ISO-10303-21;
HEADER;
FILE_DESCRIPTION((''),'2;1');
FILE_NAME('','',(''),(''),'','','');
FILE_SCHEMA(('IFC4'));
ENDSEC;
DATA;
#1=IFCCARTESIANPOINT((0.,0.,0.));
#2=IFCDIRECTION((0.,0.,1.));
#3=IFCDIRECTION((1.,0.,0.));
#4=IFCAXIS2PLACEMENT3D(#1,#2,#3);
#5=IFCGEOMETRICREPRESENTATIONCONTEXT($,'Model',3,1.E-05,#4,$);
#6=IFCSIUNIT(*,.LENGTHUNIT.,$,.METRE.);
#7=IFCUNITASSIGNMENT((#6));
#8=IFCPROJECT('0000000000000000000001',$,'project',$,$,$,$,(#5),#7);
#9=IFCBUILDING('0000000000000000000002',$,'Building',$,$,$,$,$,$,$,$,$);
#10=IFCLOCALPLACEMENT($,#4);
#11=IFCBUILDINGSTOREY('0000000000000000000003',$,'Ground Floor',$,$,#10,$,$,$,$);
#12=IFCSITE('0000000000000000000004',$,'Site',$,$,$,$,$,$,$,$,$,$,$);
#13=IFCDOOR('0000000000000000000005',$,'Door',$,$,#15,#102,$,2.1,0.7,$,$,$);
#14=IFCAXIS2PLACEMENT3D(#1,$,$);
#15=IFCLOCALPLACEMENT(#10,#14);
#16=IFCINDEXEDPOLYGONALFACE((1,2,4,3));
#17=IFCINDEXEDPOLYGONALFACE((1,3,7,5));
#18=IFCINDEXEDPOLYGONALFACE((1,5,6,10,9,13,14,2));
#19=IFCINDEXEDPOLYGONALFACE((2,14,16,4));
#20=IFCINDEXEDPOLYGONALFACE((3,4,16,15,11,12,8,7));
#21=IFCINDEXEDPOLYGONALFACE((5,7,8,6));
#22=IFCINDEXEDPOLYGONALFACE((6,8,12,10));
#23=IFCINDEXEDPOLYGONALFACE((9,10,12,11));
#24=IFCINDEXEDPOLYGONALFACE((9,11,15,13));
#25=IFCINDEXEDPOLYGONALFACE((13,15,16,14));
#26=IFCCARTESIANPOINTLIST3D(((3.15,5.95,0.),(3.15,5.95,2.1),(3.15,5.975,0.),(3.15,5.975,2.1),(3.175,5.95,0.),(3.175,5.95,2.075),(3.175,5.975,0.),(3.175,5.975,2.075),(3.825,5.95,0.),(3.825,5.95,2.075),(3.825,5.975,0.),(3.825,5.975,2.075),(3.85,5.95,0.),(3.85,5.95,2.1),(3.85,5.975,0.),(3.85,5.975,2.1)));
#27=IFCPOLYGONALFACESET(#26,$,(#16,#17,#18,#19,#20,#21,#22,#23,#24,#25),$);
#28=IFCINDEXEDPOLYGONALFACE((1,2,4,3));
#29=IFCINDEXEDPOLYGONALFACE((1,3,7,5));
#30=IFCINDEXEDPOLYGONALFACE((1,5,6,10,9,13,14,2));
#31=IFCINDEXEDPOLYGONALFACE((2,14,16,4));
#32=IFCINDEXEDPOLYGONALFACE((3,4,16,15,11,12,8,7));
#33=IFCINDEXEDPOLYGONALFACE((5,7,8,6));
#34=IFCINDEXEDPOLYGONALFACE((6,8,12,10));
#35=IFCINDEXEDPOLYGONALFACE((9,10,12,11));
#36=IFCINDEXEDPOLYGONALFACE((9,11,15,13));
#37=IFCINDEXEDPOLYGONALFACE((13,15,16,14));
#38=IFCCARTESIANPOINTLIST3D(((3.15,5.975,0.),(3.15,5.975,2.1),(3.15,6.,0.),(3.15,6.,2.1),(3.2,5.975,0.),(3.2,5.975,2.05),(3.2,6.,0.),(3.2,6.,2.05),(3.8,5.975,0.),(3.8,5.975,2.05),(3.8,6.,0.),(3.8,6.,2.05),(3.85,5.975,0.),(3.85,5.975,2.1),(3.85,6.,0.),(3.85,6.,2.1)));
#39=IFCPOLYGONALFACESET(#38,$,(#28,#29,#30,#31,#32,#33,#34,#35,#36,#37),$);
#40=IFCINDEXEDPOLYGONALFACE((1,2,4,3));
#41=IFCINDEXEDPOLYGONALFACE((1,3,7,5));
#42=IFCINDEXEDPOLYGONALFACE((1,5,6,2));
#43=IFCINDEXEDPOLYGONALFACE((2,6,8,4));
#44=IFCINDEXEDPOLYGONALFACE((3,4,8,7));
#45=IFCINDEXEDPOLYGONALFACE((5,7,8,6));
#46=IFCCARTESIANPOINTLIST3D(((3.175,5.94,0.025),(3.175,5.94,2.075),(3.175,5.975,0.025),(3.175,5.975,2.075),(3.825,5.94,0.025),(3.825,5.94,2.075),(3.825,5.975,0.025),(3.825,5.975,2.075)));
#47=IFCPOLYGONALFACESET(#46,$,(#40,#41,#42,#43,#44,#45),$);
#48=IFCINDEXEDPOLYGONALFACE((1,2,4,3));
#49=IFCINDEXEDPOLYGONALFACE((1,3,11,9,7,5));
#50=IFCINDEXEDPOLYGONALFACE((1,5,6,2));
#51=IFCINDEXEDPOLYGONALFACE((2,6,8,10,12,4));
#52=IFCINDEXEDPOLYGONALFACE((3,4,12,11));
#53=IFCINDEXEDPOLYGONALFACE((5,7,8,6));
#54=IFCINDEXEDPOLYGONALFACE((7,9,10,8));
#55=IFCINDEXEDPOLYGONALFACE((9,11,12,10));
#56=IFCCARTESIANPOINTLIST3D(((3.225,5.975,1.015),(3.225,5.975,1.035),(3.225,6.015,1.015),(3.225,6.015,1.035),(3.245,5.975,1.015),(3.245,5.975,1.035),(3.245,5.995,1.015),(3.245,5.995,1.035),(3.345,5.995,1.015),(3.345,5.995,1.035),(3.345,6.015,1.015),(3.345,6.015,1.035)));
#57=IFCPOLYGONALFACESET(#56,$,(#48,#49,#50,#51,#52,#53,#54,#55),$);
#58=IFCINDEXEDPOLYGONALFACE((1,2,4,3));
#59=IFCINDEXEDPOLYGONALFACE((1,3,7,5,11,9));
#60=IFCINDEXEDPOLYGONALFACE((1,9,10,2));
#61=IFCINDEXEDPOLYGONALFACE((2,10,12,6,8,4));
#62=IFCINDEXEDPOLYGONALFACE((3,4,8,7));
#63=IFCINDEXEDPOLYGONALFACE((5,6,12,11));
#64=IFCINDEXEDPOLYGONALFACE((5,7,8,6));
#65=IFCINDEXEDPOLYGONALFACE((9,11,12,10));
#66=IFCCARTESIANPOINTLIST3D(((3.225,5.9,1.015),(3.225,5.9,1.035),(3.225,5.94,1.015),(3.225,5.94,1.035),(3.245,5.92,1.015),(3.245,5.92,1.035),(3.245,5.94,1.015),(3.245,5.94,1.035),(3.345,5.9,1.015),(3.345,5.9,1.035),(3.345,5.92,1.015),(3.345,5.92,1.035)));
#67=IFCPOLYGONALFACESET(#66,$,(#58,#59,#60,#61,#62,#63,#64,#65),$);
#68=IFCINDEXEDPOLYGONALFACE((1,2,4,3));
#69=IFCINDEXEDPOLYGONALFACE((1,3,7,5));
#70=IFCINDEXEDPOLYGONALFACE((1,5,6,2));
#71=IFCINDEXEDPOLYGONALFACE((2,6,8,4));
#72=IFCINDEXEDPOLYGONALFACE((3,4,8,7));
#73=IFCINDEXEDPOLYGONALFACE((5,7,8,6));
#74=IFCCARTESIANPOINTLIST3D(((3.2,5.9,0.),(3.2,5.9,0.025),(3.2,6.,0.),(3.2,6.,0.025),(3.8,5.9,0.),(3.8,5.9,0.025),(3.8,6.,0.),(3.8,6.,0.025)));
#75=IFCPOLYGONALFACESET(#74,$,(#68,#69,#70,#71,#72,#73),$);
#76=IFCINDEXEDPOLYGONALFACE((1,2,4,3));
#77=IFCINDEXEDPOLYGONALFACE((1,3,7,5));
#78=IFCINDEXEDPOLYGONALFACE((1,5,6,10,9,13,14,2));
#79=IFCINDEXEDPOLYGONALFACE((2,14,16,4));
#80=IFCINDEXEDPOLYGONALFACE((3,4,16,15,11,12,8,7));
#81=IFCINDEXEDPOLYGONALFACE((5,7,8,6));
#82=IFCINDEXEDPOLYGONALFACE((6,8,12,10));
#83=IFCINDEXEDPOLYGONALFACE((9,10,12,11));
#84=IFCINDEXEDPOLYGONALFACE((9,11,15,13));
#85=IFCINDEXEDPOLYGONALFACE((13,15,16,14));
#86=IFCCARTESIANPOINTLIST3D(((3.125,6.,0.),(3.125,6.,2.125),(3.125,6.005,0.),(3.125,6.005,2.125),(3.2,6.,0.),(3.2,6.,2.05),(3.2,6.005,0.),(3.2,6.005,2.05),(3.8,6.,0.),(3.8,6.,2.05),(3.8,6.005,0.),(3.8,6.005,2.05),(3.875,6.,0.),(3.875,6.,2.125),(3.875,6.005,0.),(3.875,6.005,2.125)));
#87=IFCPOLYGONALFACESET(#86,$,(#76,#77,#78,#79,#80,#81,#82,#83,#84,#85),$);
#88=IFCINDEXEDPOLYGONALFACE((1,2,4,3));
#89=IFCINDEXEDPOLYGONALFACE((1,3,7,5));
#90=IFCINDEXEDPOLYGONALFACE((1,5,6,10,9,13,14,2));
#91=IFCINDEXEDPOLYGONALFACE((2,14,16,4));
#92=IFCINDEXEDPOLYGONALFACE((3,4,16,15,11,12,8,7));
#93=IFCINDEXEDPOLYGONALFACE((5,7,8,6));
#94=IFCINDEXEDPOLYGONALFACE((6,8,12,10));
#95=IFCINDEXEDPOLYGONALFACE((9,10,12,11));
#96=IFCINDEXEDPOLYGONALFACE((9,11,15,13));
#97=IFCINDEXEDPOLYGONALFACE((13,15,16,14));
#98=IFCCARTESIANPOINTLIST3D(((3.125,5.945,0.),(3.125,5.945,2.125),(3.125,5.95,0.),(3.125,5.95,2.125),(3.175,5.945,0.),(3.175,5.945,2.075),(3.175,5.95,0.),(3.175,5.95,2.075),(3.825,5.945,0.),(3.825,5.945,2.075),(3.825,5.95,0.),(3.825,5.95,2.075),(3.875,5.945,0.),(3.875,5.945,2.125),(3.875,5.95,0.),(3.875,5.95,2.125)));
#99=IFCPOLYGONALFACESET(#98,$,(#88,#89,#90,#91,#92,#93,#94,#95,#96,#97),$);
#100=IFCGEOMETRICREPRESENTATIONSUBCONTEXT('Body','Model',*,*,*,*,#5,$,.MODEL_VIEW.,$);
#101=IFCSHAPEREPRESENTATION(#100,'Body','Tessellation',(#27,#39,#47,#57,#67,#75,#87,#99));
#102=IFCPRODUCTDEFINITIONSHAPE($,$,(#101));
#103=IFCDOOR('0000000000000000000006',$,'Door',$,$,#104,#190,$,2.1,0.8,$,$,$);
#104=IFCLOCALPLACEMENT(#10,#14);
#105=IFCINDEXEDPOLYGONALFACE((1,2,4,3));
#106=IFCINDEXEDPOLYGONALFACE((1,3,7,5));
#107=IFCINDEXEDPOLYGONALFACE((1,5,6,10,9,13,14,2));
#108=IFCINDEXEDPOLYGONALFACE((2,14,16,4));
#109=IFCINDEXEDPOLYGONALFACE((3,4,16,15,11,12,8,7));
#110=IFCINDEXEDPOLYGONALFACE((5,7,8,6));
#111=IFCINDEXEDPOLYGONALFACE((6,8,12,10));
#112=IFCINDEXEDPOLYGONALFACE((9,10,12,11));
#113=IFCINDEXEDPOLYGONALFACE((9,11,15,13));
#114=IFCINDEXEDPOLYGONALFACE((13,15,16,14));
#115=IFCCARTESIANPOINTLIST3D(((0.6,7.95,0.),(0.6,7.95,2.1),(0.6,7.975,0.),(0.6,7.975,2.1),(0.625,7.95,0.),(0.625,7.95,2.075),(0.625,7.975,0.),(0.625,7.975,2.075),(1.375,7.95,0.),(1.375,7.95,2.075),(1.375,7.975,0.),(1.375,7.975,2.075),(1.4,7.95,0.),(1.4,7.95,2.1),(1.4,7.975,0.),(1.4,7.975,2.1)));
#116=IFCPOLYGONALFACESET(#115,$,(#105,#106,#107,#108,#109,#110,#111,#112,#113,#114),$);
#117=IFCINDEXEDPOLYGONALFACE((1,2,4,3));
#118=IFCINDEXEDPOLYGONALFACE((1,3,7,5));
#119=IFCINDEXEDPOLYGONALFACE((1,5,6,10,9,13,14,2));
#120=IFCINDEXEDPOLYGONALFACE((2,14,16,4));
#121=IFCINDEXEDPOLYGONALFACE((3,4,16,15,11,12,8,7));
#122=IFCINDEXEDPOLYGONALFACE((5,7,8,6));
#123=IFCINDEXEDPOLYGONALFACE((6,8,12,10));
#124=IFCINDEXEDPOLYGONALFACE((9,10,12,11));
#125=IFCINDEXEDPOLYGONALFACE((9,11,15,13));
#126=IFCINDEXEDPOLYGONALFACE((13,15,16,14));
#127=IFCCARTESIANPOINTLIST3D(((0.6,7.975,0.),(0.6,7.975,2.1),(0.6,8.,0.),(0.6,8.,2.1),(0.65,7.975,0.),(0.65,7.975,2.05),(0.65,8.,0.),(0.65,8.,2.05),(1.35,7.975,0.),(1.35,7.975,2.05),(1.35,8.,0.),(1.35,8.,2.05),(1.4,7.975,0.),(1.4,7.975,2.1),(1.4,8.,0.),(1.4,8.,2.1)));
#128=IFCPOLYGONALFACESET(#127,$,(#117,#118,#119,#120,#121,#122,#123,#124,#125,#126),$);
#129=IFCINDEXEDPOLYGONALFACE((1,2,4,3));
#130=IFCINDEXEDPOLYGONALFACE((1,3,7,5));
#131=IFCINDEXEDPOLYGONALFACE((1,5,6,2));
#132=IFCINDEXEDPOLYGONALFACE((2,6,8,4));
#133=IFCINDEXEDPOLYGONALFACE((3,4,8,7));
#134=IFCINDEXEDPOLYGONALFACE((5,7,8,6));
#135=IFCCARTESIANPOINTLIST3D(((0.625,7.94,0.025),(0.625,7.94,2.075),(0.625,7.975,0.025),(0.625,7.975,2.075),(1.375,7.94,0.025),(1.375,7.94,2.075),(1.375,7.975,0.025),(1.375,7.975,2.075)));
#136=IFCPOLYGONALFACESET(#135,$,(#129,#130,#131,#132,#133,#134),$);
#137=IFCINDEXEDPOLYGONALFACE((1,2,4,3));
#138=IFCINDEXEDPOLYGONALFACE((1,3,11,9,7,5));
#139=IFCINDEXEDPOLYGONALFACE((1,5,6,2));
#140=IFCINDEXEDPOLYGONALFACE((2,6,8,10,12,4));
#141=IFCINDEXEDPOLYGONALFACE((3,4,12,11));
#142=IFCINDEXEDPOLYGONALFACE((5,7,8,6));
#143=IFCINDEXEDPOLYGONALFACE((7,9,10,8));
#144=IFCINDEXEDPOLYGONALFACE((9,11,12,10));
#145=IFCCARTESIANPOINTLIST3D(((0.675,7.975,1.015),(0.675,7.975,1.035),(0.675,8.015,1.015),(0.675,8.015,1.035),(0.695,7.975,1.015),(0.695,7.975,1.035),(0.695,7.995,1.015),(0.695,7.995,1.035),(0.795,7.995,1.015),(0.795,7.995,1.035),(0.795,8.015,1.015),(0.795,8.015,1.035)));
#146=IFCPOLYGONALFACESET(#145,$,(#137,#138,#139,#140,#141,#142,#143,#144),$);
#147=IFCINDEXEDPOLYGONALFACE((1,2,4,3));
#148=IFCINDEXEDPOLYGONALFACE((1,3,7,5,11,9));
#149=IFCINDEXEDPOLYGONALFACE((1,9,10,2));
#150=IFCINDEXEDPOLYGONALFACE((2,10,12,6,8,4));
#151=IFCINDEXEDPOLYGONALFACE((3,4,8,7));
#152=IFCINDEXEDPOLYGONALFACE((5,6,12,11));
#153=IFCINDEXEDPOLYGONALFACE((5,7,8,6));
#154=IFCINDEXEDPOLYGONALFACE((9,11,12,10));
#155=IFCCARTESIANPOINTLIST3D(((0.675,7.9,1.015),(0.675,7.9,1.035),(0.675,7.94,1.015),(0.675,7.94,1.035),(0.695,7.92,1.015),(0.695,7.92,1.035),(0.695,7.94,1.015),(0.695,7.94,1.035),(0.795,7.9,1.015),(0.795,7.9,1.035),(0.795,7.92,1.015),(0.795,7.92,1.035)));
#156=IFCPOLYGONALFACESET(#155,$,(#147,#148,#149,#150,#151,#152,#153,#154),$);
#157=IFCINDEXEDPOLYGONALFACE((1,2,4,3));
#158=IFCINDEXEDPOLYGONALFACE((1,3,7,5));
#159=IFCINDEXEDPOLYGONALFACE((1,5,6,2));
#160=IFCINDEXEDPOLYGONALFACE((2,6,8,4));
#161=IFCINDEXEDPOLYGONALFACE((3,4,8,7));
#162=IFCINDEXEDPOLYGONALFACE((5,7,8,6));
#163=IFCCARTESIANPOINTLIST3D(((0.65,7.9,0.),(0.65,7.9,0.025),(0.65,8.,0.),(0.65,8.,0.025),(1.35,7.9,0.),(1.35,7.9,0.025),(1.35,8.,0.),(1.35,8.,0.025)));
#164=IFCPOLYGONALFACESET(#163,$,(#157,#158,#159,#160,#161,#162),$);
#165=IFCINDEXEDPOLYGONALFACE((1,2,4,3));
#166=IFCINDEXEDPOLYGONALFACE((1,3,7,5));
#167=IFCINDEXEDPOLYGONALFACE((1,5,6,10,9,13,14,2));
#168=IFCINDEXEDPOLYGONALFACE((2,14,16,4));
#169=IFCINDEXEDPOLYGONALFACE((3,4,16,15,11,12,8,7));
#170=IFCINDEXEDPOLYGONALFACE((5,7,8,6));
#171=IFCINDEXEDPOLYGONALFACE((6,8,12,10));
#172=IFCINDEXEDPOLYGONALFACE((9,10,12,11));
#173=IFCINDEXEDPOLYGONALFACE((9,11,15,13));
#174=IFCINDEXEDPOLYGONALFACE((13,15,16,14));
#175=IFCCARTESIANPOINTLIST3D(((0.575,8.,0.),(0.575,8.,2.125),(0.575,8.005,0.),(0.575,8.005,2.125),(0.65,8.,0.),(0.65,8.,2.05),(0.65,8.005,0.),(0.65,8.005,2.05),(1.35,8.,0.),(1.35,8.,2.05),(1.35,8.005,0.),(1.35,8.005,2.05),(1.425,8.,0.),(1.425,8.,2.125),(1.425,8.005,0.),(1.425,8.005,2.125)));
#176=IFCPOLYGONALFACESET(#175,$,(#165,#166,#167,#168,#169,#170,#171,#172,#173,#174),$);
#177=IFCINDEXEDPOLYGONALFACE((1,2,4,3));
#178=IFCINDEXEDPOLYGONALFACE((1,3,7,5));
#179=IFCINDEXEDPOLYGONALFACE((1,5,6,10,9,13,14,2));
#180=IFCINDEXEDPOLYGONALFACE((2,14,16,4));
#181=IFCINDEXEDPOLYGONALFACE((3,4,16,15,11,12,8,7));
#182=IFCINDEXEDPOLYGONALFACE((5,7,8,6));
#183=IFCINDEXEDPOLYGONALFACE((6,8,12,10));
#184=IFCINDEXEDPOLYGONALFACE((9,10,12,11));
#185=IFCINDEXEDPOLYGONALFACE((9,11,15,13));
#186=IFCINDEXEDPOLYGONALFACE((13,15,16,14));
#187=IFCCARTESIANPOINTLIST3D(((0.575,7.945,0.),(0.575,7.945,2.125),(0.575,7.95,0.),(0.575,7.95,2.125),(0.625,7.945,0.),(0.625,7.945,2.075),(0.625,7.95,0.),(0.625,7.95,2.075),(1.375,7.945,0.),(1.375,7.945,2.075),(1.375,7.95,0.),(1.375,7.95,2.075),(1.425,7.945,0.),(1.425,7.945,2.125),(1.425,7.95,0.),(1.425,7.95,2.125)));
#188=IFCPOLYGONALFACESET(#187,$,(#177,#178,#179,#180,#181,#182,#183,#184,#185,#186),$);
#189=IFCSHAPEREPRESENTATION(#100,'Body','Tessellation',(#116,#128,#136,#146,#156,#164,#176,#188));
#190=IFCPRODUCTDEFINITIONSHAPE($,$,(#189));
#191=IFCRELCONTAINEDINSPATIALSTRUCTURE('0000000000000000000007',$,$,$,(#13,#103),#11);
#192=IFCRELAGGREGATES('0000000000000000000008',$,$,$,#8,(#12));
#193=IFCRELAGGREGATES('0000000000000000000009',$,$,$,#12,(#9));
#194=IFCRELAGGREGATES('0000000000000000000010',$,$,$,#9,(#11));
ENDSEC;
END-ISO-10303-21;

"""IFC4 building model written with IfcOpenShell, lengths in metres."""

from ifc_helpers import new_model, si_unit, frame, origin_with_axes, place, context, subcontext, project, spatial, line, indexed_curve, outline, extrude, element, save


model = new_model("IFC4")

# Units and contexts
model_context = context("Model", 3, precision=1e-05, world=origin_with_axes())
body_context = subcontext(model_context, "Body", "Model", "MODEL_VIEW")
ifc_project = project(units=[si_unit("LENGTHUNIT", "METRE")], contexts=[model_context])

# Site, building, storey
site = spatial("IfcSite", under=ifc_project, Name="Site")
building = spatial("IfcBuilding", under=site, Name="Building")
storey_placement = place(None, origin_with_axes())
storey = spatial("IfcBuildingStorey", under=building, at=storey_placement, Name="Ground Floor")

# Doors
door_1_placement = place(storey_placement, frame((3.85, 6.0, 0.0), z_axis=(0.0, 0.0, 1.0), x_axis=(-1.0, 0.0, 0.0)))
element("IfcDoor", 1, at=door_1_placement, inside=storey, Name="Door", OverallHeight=2.1, OverallWidth=0.7, context=body_context, shape_type="SweptSolid", body=[
    extrude(outline(indexed_curve([(0.0, 0.0), (0.0, 2.1), (0.7, 2.1), (0.7, 0.0), (0.675, 0.0), (0.675, 2.075), (0.025, 2.075), (0.025, 0.0)], segments=[line(1, 2, 3, 4, 5, 6, 7, 8, 1)])), frame((0.0, 0.025, 0.0), z_axis=(0.0, -1.0, 0.0), x_axis=(1.0, 0.0, 0.0)), (0.0, 0.0, -1.0), 0.025),
    extrude(outline(indexed_curve([(0.0, 0.0), (0.0, 2.1), (0.7, 2.1), (0.7, 0.0), (0.65, 0.0), (0.65, 2.05), (0.05, 2.05), (0.05, 0.0)], segments=[line(1, 2, 3, 4, 5, 6, 7, 8, 1)])), frame((0.0, 0.0, 0.0), z_axis=(0.0, -1.0, 0.0), x_axis=(1.0, 0.0, 0.0)), (0.0, 0.0, -1.0), 0.025),
    extrude(outline(indexed_curve([(0.0, 0.0), (0.65, 0.0), (0.65, 0.035), (0.0, 0.035)], segments=[line(1, 2, 3, 4, 1)])), frame((0.025, 0.025, 0.025), z_axis=(0.0, 0.0, 1.0), x_axis=(1.0, 0.0, 0.0)), (0.0, 0.0, 1.0), 2.05),
    extrude(outline(indexed_curve([(0.0, 0.0), (0.0, -0.04), (-0.12, -0.04), (-0.12, -0.02), (-0.02, -0.02), (-0.02, 0.0)], segments=[line(1, 2, 3, 4, 5, 6, 1)])), frame((0.625, 0.025, 1.015), z_axis=(0.0, 0.0, 1.0), x_axis=(1.0, 0.0, 0.0)), (0.0, 0.0, 1.0), 0.02),
    extrude(outline(indexed_curve([(0.0, 0.0), (0.0, 0.04), (-0.12, 0.04), (-0.12, 0.02), (-0.02, 0.02), (-0.02, 0.0)], segments=[line(1, 2, 3, 4, 5, 6, 1)])), frame((0.625, 0.06, 1.015), z_axis=(0.0, 0.0, 1.0), x_axis=(1.0, 0.0, 0.0)), (0.0, 0.0, 1.0), 0.02),
    extrude(outline(indexed_curve([(0.0, 0.0), (0.6, 0.0), (0.6, 0.1), (0.0, 0.1)], segments=[line(1, 2, 3, 4, 1)])), frame((0.05, 0.0, 0.0), z_axis=(0.0, 0.0, 1.0), x_axis=(1.0, 0.0, 0.0)), (0.0, 0.0, 1.0), 0.025),
    extrude(outline(indexed_curve([(0.0, 0.0), (0.0, 2.125), (0.75, 2.125), (0.75, 0.0), (0.675, 0.0), (0.675, 2.05), (0.075, 2.05), (0.075, 0.0)], segments=[line(1, 2, 3, 4, 5, 6, 7, 8, 1)])), frame((-0.025, -0.005, 0.0), z_axis=(0.0, -1.0, 0.0), x_axis=(1.0, 0.0, 0.0)), (0.0, 0.0, -1.0), 0.005),
    extrude(outline(indexed_curve([(0.0, 0.0), (0.0, 2.125), (0.75, 2.125), (0.75, 0.0), (0.7, 0.0), (0.7, 2.075), (0.05, 2.075), (0.05, 0.0)], segments=[line(1, 2, 3, 4, 5, 6, 7, 8, 1)])), frame((-0.025, 0.05, 0.0), z_axis=(0.0, -1.0, 0.0), x_axis=(1.0, 0.0, 0.0)), (0.0, 0.0, -1.0), 0.005),
])
door_2_placement = place(storey_placement, frame((1.4, 8.0, 0.0), z_axis=(0.0, 0.0, 1.0), x_axis=(-1.0, 0.0, 0.0)))
element("IfcDoor", 2, at=door_2_placement, inside=storey, Name="Door", OverallHeight=2.1, OverallWidth=0.8, context=body_context, shape_type="SweptSolid", body=[
    extrude(outline(indexed_curve([(0.0, 0.0), (0.0, 2.1), (0.8, 2.1), (0.8, 0.0), (0.775, 0.0), (0.775, 2.075), (0.025, 2.075), (0.025, 0.0)], segments=[line(1, 2, 3, 4, 5, 6, 7, 8, 1)])), frame((0.0, 0.025, 0.0), z_axis=(0.0, -1.0, 0.0), x_axis=(1.0, 0.0, 0.0)), (0.0, 0.0, -1.0), 0.025),
    extrude(outline(indexed_curve([(0.0, 0.0), (0.0, 2.1), (0.8, 2.1), (0.8, 0.0), (0.75, 0.0), (0.75, 2.05), (0.05, 2.05), (0.05, 0.0)], segments=[line(1, 2, 3, 4, 5, 6, 7, 8, 1)])), frame((0.0, 0.0, 0.0), z_axis=(0.0, -1.0, 0.0), x_axis=(1.0, 0.0, 0.0)), (0.0, 0.0, -1.0), 0.025),
    extrude(outline(indexed_curve([(0.0, 0.0), (0.75, 0.0), (0.75, 0.035), (0.0, 0.035)], segments=[line(1, 2, 3, 4, 1)])), frame((0.025, 0.025, 0.025), z_axis=(0.0, 0.0, 1.0), x_axis=(1.0, 0.0, 0.0)), (0.0, 0.0, 1.0), 2.05),
    extrude(outline(indexed_curve([(0.0, 0.0), (0.0, -0.04), (-0.12, -0.04), (-0.12, -0.02), (-0.02, -0.02), (-0.02, 0.0)], segments=[line(1, 2, 3, 4, 5, 6, 1)])), frame((0.725, 0.025, 1.015), z_axis=(0.0, 0.0, 1.0), x_axis=(1.0, 0.0, 0.0)), (0.0, 0.0, 1.0), 0.02),
    extrude(outline(indexed_curve([(0.0, 0.0), (0.0, 0.04), (-0.12, 0.04), (-0.12, 0.02), (-0.02, 0.02), (-0.02, 0.0)], segments=[line(1, 2, 3, 4, 5, 6, 1)])), frame((0.725, 0.06, 1.015), z_axis=(0.0, 0.0, 1.0), x_axis=(1.0, 0.0, 0.0)), (0.0, 0.0, 1.0), 0.02),
    extrude(outline(indexed_curve([(0.0, 0.0), (0.7, 0.0), (0.7, 0.1), (0.0, 0.1)], segments=[line(1, 2, 3, 4, 1)])), frame((0.05, 0.0, 0.0), z_axis=(0.0, 0.0, 1.0), x_axis=(1.0, 0.0, 0.0)), (0.0, 0.0, 1.0), 0.025),
    extrude(outline(indexed_curve([(0.0, 0.0), (0.0, 2.125), (0.85, 2.125), (0.85, 0.0), (0.775, 0.0), (0.775, 2.05), (0.075, 2.05), (0.075, 0.0)], segments=[line(1, 2, 3, 4, 5, 6, 7, 8, 1)])), frame((-0.025, -0.005, 0.0), z_axis=(0.0, -1.0, 0.0), x_axis=(1.0, 0.0, 0.0)), (0.0, 0.0, -1.0), 0.005),
    extrude(outline(indexed_curve([(0.0, 0.0), (0.0, 2.125), (0.85, 2.125), (0.85, 0.0), (0.8, 0.0), (0.8, 2.075), (0.05, 2.075), (0.05, 0.0)], segments=[line(1, 2, 3, 4, 5, 6, 7, 8, 1)])), frame((-0.025, 0.05, 0.0), z_axis=(0.0, -1.0, 0.0), x_axis=(1.0, 0.0, 0.0)), (0.0, 0.0, -1.0), 0.005),
])

save(model, "model.ifc")
